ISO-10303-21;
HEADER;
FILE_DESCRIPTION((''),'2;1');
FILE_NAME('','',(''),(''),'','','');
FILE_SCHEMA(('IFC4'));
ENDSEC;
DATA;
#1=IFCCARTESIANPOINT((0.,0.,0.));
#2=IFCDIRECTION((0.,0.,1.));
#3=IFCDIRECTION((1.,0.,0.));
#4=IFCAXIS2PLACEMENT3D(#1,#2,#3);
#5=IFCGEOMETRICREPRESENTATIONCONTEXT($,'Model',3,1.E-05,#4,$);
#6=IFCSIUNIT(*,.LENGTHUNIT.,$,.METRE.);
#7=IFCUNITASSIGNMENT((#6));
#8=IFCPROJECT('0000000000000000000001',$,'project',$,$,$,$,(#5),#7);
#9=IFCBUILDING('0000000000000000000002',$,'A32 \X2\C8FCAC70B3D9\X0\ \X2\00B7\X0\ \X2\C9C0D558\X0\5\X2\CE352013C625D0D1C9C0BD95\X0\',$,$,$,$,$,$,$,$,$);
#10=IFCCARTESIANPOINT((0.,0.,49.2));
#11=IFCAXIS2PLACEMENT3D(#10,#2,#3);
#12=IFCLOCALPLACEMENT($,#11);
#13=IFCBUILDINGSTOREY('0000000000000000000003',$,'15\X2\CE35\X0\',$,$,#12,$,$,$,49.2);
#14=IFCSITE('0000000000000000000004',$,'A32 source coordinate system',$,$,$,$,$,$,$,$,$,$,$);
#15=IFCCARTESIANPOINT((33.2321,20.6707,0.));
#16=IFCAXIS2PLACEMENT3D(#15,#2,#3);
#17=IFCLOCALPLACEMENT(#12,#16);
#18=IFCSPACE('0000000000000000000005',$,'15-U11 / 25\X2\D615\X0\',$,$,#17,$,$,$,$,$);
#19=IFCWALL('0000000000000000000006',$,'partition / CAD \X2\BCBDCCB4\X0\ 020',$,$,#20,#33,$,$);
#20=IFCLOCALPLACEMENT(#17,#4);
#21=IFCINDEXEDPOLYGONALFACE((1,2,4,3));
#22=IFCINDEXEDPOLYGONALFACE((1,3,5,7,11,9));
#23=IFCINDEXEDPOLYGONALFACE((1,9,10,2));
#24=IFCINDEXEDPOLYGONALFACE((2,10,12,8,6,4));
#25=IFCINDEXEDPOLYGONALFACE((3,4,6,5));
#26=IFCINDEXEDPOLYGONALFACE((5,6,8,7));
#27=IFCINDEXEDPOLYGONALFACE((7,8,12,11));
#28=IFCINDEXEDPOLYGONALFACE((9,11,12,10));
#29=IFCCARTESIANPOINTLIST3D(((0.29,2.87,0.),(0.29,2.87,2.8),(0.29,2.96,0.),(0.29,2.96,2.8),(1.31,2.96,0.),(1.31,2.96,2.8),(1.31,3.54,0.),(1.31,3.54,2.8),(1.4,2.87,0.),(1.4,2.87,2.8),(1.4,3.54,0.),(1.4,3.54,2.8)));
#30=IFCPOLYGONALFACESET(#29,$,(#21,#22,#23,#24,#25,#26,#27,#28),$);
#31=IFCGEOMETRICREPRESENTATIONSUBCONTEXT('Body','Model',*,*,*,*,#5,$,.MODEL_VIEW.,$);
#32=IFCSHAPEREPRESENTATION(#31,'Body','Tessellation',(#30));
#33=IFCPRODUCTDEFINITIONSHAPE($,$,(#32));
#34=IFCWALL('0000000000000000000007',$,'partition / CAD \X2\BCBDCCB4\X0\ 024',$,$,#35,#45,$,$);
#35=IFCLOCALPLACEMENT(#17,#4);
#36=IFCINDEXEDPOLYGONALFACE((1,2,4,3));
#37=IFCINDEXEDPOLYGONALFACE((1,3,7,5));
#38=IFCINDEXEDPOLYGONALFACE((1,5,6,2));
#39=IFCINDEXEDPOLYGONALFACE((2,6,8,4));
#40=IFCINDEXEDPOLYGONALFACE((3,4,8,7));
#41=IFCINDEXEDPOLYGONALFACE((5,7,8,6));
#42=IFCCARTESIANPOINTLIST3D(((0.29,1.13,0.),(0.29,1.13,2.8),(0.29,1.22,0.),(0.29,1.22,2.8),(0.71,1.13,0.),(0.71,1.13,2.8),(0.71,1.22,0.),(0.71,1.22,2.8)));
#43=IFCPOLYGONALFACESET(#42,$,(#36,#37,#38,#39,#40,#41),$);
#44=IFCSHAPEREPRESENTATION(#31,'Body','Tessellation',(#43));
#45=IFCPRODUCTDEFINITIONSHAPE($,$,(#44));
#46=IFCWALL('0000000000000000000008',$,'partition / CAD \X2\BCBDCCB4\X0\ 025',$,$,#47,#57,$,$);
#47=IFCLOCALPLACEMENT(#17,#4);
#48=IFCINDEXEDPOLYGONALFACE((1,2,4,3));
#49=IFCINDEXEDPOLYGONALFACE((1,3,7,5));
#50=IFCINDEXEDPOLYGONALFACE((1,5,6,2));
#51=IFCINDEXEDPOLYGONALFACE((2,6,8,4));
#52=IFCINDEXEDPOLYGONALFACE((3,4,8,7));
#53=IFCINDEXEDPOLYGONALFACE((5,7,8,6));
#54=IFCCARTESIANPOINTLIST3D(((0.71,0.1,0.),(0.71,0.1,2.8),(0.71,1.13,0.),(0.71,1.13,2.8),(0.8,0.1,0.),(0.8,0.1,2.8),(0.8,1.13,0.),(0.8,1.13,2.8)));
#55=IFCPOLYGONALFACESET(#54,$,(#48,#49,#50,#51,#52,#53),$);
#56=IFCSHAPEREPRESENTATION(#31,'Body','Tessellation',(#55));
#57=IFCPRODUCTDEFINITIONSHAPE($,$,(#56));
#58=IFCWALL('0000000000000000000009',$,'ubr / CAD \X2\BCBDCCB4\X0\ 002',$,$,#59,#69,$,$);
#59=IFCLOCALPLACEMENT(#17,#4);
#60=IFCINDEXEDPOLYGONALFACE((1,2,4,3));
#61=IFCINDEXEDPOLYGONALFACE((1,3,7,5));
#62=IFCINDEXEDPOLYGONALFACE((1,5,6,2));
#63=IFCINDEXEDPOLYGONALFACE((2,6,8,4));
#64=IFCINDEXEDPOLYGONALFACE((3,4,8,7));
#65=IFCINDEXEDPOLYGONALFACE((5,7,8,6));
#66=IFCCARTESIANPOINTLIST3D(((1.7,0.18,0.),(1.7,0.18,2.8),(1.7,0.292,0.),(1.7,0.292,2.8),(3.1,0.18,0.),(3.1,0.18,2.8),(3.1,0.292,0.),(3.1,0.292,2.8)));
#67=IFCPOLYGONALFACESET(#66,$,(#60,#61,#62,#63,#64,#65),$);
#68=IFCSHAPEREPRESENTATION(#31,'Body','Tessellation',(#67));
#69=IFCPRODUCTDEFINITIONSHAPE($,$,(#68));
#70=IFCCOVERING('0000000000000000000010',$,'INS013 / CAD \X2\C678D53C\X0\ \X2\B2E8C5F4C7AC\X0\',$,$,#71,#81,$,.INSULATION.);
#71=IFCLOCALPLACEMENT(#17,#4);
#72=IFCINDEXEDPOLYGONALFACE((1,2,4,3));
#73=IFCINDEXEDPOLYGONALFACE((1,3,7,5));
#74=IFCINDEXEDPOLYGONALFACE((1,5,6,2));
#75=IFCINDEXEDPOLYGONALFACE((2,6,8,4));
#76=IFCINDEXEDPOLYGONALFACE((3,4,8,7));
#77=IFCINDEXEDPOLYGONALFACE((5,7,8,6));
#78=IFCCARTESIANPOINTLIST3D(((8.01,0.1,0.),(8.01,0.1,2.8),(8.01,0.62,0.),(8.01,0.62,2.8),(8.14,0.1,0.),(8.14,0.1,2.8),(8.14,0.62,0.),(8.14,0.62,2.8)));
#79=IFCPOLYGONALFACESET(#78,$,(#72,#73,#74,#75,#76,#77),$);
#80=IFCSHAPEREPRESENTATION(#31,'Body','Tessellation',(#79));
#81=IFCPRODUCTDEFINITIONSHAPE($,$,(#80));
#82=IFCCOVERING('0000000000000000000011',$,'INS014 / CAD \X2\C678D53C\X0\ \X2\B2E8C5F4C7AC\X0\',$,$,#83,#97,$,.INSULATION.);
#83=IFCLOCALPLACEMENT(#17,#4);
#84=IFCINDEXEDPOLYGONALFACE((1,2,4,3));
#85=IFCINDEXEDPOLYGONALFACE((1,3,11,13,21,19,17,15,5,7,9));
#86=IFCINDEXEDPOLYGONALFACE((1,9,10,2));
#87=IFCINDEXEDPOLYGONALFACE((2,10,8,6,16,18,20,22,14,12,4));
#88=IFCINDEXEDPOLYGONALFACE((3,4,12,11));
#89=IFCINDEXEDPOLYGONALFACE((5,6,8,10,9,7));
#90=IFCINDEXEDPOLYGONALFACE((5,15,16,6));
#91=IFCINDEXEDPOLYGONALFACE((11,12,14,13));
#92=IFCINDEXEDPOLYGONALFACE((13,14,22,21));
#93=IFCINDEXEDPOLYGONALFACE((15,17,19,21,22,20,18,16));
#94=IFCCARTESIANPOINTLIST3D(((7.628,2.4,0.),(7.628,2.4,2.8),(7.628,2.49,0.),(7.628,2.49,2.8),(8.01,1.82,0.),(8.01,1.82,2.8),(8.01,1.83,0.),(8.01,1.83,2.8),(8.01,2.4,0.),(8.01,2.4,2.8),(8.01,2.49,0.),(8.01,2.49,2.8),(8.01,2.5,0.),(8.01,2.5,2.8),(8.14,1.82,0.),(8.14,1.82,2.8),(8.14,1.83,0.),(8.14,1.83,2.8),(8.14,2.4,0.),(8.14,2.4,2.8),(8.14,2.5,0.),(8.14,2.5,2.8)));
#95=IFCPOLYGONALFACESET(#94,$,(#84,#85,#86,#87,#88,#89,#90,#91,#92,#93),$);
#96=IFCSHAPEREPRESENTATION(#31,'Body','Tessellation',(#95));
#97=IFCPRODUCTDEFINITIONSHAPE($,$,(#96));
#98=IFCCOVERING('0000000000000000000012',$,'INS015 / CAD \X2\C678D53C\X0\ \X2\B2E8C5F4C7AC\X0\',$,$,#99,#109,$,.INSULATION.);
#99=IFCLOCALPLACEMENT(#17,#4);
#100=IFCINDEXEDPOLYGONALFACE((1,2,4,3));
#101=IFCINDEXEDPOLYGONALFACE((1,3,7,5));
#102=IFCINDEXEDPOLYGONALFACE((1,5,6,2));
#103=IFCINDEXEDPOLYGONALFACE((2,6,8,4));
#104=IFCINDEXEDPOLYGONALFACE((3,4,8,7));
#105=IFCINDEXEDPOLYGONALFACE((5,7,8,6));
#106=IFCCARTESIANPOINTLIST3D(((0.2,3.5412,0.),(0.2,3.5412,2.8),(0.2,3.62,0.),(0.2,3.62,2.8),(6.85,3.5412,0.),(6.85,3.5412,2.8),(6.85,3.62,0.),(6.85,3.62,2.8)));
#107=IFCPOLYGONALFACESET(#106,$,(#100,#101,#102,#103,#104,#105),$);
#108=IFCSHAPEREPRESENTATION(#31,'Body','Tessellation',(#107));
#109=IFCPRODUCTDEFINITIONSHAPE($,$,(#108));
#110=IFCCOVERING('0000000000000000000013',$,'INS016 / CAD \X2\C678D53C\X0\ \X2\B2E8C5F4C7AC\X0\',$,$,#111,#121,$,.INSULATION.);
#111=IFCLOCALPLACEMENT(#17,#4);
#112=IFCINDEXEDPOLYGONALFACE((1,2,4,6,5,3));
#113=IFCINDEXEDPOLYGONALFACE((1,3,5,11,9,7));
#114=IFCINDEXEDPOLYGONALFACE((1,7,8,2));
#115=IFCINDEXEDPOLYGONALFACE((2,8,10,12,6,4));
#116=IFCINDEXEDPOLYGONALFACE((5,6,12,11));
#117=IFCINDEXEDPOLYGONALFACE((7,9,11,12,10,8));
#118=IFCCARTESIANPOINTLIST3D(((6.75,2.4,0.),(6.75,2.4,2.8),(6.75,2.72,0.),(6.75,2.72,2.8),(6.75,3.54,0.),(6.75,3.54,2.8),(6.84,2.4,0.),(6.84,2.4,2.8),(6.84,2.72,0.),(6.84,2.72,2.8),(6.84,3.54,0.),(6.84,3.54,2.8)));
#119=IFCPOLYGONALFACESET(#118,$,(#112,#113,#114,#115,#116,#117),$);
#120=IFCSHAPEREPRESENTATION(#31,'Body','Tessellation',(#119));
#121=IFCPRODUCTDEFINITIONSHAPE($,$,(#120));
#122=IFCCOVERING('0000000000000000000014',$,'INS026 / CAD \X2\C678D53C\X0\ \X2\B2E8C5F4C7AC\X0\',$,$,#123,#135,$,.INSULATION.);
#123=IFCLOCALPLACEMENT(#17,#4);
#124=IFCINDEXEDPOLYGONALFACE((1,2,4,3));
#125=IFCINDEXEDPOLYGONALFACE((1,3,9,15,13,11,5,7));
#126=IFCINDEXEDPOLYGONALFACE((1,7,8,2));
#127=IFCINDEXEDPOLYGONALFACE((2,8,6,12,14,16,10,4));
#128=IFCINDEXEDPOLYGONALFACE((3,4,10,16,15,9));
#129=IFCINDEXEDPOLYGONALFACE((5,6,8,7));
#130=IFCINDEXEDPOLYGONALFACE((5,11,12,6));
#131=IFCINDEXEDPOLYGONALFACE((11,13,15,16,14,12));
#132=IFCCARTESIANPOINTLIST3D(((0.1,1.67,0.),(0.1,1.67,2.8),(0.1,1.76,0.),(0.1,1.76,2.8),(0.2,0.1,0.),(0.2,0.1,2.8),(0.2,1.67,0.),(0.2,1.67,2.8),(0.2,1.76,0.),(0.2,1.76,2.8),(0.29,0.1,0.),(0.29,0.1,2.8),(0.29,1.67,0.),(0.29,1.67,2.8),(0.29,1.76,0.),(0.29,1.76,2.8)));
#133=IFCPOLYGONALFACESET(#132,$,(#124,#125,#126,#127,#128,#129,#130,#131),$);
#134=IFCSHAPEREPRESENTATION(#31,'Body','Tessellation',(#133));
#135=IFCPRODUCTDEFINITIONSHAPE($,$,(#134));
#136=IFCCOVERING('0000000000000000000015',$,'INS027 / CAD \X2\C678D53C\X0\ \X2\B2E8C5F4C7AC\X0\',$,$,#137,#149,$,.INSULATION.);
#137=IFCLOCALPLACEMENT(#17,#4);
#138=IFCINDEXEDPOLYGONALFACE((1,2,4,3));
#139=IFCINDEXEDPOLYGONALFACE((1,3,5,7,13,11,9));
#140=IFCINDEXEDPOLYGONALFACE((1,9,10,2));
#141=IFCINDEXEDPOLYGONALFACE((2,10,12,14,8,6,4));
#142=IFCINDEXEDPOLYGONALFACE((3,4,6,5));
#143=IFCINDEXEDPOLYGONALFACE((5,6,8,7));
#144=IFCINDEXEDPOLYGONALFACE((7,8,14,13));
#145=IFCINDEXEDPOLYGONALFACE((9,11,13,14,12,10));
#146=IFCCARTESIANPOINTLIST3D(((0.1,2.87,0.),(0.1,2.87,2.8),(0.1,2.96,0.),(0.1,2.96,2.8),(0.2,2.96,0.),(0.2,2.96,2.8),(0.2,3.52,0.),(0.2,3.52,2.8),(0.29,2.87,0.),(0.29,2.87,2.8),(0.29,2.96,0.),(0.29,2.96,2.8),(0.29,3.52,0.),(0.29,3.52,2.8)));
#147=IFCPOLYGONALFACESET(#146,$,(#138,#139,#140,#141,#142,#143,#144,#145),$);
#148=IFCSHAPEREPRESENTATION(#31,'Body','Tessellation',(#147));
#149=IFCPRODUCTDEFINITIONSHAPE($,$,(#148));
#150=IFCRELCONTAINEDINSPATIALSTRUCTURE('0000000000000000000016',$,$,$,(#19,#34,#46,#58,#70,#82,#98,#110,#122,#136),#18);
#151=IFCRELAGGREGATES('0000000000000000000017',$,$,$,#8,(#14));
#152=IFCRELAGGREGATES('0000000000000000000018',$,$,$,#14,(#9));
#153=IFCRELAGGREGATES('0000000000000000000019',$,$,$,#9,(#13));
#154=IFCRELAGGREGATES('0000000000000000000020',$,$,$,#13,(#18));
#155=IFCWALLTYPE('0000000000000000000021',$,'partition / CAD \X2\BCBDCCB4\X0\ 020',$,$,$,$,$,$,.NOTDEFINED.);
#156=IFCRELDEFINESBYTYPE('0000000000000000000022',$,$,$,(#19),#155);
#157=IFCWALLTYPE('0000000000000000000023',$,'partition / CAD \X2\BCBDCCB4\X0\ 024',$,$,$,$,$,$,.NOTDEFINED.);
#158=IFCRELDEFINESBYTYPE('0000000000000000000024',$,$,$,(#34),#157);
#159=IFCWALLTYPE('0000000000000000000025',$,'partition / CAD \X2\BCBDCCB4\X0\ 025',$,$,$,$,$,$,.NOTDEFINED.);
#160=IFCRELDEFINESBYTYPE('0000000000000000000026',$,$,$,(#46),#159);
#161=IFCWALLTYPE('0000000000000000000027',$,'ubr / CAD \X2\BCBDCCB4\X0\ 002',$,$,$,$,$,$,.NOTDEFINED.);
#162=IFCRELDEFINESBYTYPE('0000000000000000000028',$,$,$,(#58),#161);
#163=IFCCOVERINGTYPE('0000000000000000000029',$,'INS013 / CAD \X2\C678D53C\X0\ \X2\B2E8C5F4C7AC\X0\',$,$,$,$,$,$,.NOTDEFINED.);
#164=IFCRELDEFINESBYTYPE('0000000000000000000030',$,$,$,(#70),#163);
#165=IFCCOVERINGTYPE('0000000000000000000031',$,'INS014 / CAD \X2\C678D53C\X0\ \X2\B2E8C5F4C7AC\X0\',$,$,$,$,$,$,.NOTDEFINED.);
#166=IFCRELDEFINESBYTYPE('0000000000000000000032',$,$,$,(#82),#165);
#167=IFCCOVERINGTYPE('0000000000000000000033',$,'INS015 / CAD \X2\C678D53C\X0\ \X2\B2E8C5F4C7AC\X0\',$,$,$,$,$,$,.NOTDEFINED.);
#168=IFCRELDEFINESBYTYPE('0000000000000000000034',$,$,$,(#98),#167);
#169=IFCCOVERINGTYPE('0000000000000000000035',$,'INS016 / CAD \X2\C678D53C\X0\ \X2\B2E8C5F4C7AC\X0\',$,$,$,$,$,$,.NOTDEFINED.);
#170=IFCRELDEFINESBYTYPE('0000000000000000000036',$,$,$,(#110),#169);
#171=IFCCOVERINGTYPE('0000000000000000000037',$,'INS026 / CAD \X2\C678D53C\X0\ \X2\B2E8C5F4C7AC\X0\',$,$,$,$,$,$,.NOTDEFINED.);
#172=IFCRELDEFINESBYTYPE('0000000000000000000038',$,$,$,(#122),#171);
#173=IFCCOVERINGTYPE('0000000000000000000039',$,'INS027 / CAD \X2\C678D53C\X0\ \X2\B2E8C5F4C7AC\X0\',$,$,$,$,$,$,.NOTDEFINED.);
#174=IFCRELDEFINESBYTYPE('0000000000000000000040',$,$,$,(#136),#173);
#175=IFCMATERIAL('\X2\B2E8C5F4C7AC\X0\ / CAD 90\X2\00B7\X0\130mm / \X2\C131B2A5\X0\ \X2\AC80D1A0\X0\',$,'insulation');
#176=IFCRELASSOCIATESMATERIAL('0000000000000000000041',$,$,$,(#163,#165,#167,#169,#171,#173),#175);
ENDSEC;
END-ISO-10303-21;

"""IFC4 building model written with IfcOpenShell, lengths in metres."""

from ifc_helpers import new_model, si_unit, frame, origin, origin_with_axes, place, context, subcontext, project, spatial, polyline, outline, extrude, source, transform, mapped, material, type_object, type_shapes, element, save


model = new_model("IFC4")

# Units and contexts
model_context = context("Model", 3, precision=1e-05, world=origin_with_axes())
body_context = subcontext(model_context, "Body", "Model", "MODEL_VIEW")
ifc_project = project(units=[si_unit("LENGTHUNIT", "METRE")], contexts=[model_context])

# Site, building, storey, space
storey_placement = place(None, frame((0.0, 0.0, 49.2), z_axis=(0.0, 0.0, 1.0), x_axis=(1.0, 0.0, 0.0)))
space_placement = place(storey_placement, frame((33.2321, 20.6707, 0.0), z_axis=(0.0, 0.0, 1.0), x_axis=(1.0, 0.0, 0.0)))
site = spatial("IfcSite", under=ifc_project, Name="A32 source coordinate system")
building = spatial("IfcBuilding", under=site, Name="A32 주거동 · 지하5층–옥탑지붕")
storey = spatial("IfcBuildingStorey", under=building, at=storey_placement, Name="15층", Elevation=49.2)
space = spatial("IfcSpace", under=storey, at=space_placement, Name="15-U11 / 25형")

# Walls
wall_type_1 = type_object("IfcWallType", Name="partition / CAD 벽체 020", PredefinedType="NOTDEFINED")
shared_shape_1 = source(origin(), body_context, "Body", "SweptSolid", [
    extrude(outline(polyline([(0.29, 2.87), (0.29, 2.96), (1.31, 2.96), (1.31, 3.54), (1.4, 3.54), (1.4, 2.87), (0.29, 2.87)])), origin(), (0.0, 0.0, 1.0), 2.8),
])
type_shapes(wall_type_1, [shared_shape_1])
wall_1_placement = place(space_placement, origin_with_axes())
element("IfcWall", 1, at=wall_1_placement, inside=space, type_object=wall_type_1, Name="partition / CAD 벽체 020", context=body_context, shape_type="MappedRepresentation", body=[
    mapped(shared_shape_1, transform((0.0, 0.0, 0.0), scale=1.0)),
])
wall_type_2 = type_object("IfcWallType", Name="partition / CAD 벽체 024", PredefinedType="NOTDEFINED")
shared_shape_2 = source(origin(), body_context, "Body", "SweptSolid", [
    extrude(outline(polyline([(0.71, 1.13), (0.29, 1.13), (0.29, 1.22), (0.71, 1.22), (0.71, 1.13)])), origin(), (0.0, 0.0, 1.0), 2.8),
])
type_shapes(wall_type_2, [shared_shape_2])
wall_2_placement = place(space_placement, origin_with_axes())
element("IfcWall", 2, at=wall_2_placement, inside=space, type_object=wall_type_2, Name="partition / CAD 벽체 024", context=body_context, shape_type="MappedRepresentation", body=[
    mapped(shared_shape_2, transform((0.0, 0.0, 0.0), scale=1.0)),
])
wall_type_3 = type_object("IfcWallType", Name="partition / CAD 벽체 025", PredefinedType="NOTDEFINED")
shared_shape_3 = source(origin(), body_context, "Body", "SweptSolid", [
    extrude(outline(polyline([(0.71, 1.13), (0.8, 1.13), (0.8, 0.1), (0.71, 0.1), (0.71, 1.13)])), origin(), (0.0, 0.0, 1.0), 2.8),
])
type_shapes(wall_type_3, [shared_shape_3])
wall_3_placement = place(space_placement, origin_with_axes())
element("IfcWall", 3, at=wall_3_placement, inside=space, type_object=wall_type_3, Name="partition / CAD 벽체 025", context=body_context, shape_type="MappedRepresentation", body=[
    mapped(shared_shape_3, transform((0.0, 0.0, 0.0), scale=1.0)),
])
wall_type_4 = type_object("IfcWallType", Name="ubr / CAD 벽체 002", PredefinedType="NOTDEFINED")
shared_shape_4 = source(origin(), body_context, "Body", "SweptSolid", [
    extrude(outline(polyline([(3.1, 0.292), (3.1, 0.18), (1.7, 0.18), (1.7, 0.292), (3.1, 0.292)])), origin(), (0.0, 0.0, 1.0), 2.8),
])
type_shapes(wall_type_4, [shared_shape_4])
wall_4_placement = place(space_placement, origin_with_axes())
element("IfcWall", 4, at=wall_4_placement, inside=space, type_object=wall_type_4, Name="ubr / CAD 벽체 002", context=body_context, shape_type="MappedRepresentation", body=[
    mapped(shared_shape_4, transform((0.0, 0.0, 0.0), scale=1.0)),
])

# Coverings
ifc_material = material(Name="단열재 / CAD 90·130mm / 성능 검토", Category="insulation")
covering_type_1 = type_object("IfcCoveringType", Name="INS013 / CAD 외피 단열재", PredefinedType="NOTDEFINED", material=ifc_material)
shared_shape_5 = source(origin(), body_context, "Body", "SweptSolid", [
    extrude(outline(polyline([(8.14, 0.1), (8.01, 0.1), (8.01, 0.62), (8.14, 0.62), (8.14, 0.1)])), origin(), (0.0, 0.0, 1.0), 2.8),
])
type_shapes(covering_type_1, [shared_shape_5])
covering_1_placement = place(space_placement, origin_with_axes())
element("IfcCovering", 5, at=covering_1_placement, inside=space, type_object=covering_type_1, Name="INS013 / CAD 외피 단열재", PredefinedType="INSULATION", context=body_context, shape_type="MappedRepresentation", body=[
    mapped(shared_shape_5, transform((0.0, 0.0, 0.0), scale=1.0)),
])
covering_type_2 = type_object("IfcCoveringType", Name="INS014 / CAD 외피 단열재", PredefinedType="NOTDEFINED", material=ifc_material)
shared_shape_6 = source(origin(), body_context, "Body", "SweptSolid", [
    extrude(outline(polyline([(8.14, 2.5), (8.14, 2.4), (8.14, 1.83), (8.14, 1.82), (8.01, 1.82), (8.01, 1.83), (8.01, 2.4), (7.628, 2.4), (7.628, 2.49), (8.01, 2.49), (8.01, 2.5), (8.14, 2.5)])), origin(), (0.0, 0.0, 1.0), 2.8),
])
type_shapes(covering_type_2, [shared_shape_6])
covering_2_placement = place(space_placement, origin_with_axes())
element("IfcCovering", 6, at=covering_2_placement, inside=space, type_object=covering_type_2, Name="INS014 / CAD 외피 단열재", PredefinedType="INSULATION", context=body_context, shape_type="MappedRepresentation", body=[
    mapped(shared_shape_6, transform((0.0, 0.0, 0.0), scale=1.0)),
])
covering_type_3 = type_object("IfcCoveringType", Name="INS015 / CAD 외피 단열재", PredefinedType="NOTDEFINED", material=ifc_material)
shared_shape_7 = source(origin(), body_context, "Body", "SweptSolid", [
    extrude(outline(polyline([(0.2, 3.5412), (0.2, 3.62), (6.85, 3.62), (6.85, 3.5412), (0.2, 3.5412)])), origin(), (0.0, 0.0, 1.0), 2.8),
])
type_shapes(covering_type_3, [shared_shape_7])
covering_3_placement = place(space_placement, origin_with_axes())
element("IfcCovering", 7, at=covering_3_placement, inside=space, type_object=covering_type_3, Name="INS015 / CAD 외피 단열재", PredefinedType="INSULATION", context=body_context, shape_type="MappedRepresentation", body=[
    mapped(shared_shape_7, transform((0.0, 0.0, 0.0), scale=1.0)),
])
covering_type_4 = type_object("IfcCoveringType", Name="INS016 / CAD 외피 단열재", PredefinedType="NOTDEFINED", material=ifc_material)
shared_shape_8 = source(origin(), body_context, "Body", "SweptSolid", [
    extrude(outline(polyline([(6.84, 2.72), (6.84, 2.4), (6.75, 2.4), (6.75, 2.72), (6.75, 3.54), (6.84, 3.54), (6.84, 2.72)])), origin(), (0.0, 0.0, 1.0), 2.8),
])
type_shapes(covering_type_4, [shared_shape_8])
covering_4_placement = place(space_placement, origin_with_axes())
element("IfcCovering", 8, at=covering_4_placement, inside=space, type_object=covering_type_4, Name="INS016 / CAD 외피 단열재", PredefinedType="INSULATION", context=body_context, shape_type="MappedRepresentation", body=[
    mapped(shared_shape_8, transform((0.0, 0.0, 0.0), scale=1.0)),
])
covering_type_5 = type_object("IfcCoveringType", Name="INS026 / CAD 외피 단열재", PredefinedType="NOTDEFINED", material=ifc_material)
shared_shape_9 = source(origin(), body_context, "Body", "SweptSolid", [
    extrude(outline(polyline([(0.2, 1.76), (0.29, 1.76), (0.29, 1.67), (0.29, 0.1), (0.2, 0.1), (0.2, 1.67), (0.1, 1.67), (0.1, 1.76), (0.2, 1.76)])), origin(), (0.0, 0.0, 1.0), 2.8),
])
type_shapes(covering_type_5, [shared_shape_9])
covering_5_placement = place(space_placement, origin_with_axes())
element("IfcCovering", 9, at=covering_5_placement, inside=space, type_object=covering_type_5, Name="INS026 / CAD 외피 단열재", PredefinedType="INSULATION", context=body_context, shape_type="MappedRepresentation", body=[
    mapped(shared_shape_9, transform((0.0, 0.0, 0.0), scale=1.0)),
])
covering_type_6 = type_object("IfcCoveringType", Name="INS027 / CAD 외피 단열재", PredefinedType="NOTDEFINED", material=ifc_material)
shared_shape_10 = source(origin(), body_context, "Body", "SweptSolid", [
    extrude(outline(polyline([(0.2, 3.52), (0.29, 3.52), (0.29, 2.96), (0.29, 2.87), (0.1, 2.87), (0.1, 2.96), (0.2, 2.96), (0.2, 3.52)])), origin(), (0.0, 0.0, 1.0), 2.8),
])
type_shapes(covering_type_6, [shared_shape_10])
covering_6_placement = place(space_placement, origin_with_axes())
element("IfcCovering", 10, at=covering_6_placement, inside=space, type_object=covering_type_6, Name="INS027 / CAD 외피 단열재", PredefinedType="INSULATION", context=body_context, shape_type="MappedRepresentation", body=[
    mapped(shared_shape_10, transform((0.0, 0.0, 0.0), scale=1.0)),
])

save(model, "model.ifc")
